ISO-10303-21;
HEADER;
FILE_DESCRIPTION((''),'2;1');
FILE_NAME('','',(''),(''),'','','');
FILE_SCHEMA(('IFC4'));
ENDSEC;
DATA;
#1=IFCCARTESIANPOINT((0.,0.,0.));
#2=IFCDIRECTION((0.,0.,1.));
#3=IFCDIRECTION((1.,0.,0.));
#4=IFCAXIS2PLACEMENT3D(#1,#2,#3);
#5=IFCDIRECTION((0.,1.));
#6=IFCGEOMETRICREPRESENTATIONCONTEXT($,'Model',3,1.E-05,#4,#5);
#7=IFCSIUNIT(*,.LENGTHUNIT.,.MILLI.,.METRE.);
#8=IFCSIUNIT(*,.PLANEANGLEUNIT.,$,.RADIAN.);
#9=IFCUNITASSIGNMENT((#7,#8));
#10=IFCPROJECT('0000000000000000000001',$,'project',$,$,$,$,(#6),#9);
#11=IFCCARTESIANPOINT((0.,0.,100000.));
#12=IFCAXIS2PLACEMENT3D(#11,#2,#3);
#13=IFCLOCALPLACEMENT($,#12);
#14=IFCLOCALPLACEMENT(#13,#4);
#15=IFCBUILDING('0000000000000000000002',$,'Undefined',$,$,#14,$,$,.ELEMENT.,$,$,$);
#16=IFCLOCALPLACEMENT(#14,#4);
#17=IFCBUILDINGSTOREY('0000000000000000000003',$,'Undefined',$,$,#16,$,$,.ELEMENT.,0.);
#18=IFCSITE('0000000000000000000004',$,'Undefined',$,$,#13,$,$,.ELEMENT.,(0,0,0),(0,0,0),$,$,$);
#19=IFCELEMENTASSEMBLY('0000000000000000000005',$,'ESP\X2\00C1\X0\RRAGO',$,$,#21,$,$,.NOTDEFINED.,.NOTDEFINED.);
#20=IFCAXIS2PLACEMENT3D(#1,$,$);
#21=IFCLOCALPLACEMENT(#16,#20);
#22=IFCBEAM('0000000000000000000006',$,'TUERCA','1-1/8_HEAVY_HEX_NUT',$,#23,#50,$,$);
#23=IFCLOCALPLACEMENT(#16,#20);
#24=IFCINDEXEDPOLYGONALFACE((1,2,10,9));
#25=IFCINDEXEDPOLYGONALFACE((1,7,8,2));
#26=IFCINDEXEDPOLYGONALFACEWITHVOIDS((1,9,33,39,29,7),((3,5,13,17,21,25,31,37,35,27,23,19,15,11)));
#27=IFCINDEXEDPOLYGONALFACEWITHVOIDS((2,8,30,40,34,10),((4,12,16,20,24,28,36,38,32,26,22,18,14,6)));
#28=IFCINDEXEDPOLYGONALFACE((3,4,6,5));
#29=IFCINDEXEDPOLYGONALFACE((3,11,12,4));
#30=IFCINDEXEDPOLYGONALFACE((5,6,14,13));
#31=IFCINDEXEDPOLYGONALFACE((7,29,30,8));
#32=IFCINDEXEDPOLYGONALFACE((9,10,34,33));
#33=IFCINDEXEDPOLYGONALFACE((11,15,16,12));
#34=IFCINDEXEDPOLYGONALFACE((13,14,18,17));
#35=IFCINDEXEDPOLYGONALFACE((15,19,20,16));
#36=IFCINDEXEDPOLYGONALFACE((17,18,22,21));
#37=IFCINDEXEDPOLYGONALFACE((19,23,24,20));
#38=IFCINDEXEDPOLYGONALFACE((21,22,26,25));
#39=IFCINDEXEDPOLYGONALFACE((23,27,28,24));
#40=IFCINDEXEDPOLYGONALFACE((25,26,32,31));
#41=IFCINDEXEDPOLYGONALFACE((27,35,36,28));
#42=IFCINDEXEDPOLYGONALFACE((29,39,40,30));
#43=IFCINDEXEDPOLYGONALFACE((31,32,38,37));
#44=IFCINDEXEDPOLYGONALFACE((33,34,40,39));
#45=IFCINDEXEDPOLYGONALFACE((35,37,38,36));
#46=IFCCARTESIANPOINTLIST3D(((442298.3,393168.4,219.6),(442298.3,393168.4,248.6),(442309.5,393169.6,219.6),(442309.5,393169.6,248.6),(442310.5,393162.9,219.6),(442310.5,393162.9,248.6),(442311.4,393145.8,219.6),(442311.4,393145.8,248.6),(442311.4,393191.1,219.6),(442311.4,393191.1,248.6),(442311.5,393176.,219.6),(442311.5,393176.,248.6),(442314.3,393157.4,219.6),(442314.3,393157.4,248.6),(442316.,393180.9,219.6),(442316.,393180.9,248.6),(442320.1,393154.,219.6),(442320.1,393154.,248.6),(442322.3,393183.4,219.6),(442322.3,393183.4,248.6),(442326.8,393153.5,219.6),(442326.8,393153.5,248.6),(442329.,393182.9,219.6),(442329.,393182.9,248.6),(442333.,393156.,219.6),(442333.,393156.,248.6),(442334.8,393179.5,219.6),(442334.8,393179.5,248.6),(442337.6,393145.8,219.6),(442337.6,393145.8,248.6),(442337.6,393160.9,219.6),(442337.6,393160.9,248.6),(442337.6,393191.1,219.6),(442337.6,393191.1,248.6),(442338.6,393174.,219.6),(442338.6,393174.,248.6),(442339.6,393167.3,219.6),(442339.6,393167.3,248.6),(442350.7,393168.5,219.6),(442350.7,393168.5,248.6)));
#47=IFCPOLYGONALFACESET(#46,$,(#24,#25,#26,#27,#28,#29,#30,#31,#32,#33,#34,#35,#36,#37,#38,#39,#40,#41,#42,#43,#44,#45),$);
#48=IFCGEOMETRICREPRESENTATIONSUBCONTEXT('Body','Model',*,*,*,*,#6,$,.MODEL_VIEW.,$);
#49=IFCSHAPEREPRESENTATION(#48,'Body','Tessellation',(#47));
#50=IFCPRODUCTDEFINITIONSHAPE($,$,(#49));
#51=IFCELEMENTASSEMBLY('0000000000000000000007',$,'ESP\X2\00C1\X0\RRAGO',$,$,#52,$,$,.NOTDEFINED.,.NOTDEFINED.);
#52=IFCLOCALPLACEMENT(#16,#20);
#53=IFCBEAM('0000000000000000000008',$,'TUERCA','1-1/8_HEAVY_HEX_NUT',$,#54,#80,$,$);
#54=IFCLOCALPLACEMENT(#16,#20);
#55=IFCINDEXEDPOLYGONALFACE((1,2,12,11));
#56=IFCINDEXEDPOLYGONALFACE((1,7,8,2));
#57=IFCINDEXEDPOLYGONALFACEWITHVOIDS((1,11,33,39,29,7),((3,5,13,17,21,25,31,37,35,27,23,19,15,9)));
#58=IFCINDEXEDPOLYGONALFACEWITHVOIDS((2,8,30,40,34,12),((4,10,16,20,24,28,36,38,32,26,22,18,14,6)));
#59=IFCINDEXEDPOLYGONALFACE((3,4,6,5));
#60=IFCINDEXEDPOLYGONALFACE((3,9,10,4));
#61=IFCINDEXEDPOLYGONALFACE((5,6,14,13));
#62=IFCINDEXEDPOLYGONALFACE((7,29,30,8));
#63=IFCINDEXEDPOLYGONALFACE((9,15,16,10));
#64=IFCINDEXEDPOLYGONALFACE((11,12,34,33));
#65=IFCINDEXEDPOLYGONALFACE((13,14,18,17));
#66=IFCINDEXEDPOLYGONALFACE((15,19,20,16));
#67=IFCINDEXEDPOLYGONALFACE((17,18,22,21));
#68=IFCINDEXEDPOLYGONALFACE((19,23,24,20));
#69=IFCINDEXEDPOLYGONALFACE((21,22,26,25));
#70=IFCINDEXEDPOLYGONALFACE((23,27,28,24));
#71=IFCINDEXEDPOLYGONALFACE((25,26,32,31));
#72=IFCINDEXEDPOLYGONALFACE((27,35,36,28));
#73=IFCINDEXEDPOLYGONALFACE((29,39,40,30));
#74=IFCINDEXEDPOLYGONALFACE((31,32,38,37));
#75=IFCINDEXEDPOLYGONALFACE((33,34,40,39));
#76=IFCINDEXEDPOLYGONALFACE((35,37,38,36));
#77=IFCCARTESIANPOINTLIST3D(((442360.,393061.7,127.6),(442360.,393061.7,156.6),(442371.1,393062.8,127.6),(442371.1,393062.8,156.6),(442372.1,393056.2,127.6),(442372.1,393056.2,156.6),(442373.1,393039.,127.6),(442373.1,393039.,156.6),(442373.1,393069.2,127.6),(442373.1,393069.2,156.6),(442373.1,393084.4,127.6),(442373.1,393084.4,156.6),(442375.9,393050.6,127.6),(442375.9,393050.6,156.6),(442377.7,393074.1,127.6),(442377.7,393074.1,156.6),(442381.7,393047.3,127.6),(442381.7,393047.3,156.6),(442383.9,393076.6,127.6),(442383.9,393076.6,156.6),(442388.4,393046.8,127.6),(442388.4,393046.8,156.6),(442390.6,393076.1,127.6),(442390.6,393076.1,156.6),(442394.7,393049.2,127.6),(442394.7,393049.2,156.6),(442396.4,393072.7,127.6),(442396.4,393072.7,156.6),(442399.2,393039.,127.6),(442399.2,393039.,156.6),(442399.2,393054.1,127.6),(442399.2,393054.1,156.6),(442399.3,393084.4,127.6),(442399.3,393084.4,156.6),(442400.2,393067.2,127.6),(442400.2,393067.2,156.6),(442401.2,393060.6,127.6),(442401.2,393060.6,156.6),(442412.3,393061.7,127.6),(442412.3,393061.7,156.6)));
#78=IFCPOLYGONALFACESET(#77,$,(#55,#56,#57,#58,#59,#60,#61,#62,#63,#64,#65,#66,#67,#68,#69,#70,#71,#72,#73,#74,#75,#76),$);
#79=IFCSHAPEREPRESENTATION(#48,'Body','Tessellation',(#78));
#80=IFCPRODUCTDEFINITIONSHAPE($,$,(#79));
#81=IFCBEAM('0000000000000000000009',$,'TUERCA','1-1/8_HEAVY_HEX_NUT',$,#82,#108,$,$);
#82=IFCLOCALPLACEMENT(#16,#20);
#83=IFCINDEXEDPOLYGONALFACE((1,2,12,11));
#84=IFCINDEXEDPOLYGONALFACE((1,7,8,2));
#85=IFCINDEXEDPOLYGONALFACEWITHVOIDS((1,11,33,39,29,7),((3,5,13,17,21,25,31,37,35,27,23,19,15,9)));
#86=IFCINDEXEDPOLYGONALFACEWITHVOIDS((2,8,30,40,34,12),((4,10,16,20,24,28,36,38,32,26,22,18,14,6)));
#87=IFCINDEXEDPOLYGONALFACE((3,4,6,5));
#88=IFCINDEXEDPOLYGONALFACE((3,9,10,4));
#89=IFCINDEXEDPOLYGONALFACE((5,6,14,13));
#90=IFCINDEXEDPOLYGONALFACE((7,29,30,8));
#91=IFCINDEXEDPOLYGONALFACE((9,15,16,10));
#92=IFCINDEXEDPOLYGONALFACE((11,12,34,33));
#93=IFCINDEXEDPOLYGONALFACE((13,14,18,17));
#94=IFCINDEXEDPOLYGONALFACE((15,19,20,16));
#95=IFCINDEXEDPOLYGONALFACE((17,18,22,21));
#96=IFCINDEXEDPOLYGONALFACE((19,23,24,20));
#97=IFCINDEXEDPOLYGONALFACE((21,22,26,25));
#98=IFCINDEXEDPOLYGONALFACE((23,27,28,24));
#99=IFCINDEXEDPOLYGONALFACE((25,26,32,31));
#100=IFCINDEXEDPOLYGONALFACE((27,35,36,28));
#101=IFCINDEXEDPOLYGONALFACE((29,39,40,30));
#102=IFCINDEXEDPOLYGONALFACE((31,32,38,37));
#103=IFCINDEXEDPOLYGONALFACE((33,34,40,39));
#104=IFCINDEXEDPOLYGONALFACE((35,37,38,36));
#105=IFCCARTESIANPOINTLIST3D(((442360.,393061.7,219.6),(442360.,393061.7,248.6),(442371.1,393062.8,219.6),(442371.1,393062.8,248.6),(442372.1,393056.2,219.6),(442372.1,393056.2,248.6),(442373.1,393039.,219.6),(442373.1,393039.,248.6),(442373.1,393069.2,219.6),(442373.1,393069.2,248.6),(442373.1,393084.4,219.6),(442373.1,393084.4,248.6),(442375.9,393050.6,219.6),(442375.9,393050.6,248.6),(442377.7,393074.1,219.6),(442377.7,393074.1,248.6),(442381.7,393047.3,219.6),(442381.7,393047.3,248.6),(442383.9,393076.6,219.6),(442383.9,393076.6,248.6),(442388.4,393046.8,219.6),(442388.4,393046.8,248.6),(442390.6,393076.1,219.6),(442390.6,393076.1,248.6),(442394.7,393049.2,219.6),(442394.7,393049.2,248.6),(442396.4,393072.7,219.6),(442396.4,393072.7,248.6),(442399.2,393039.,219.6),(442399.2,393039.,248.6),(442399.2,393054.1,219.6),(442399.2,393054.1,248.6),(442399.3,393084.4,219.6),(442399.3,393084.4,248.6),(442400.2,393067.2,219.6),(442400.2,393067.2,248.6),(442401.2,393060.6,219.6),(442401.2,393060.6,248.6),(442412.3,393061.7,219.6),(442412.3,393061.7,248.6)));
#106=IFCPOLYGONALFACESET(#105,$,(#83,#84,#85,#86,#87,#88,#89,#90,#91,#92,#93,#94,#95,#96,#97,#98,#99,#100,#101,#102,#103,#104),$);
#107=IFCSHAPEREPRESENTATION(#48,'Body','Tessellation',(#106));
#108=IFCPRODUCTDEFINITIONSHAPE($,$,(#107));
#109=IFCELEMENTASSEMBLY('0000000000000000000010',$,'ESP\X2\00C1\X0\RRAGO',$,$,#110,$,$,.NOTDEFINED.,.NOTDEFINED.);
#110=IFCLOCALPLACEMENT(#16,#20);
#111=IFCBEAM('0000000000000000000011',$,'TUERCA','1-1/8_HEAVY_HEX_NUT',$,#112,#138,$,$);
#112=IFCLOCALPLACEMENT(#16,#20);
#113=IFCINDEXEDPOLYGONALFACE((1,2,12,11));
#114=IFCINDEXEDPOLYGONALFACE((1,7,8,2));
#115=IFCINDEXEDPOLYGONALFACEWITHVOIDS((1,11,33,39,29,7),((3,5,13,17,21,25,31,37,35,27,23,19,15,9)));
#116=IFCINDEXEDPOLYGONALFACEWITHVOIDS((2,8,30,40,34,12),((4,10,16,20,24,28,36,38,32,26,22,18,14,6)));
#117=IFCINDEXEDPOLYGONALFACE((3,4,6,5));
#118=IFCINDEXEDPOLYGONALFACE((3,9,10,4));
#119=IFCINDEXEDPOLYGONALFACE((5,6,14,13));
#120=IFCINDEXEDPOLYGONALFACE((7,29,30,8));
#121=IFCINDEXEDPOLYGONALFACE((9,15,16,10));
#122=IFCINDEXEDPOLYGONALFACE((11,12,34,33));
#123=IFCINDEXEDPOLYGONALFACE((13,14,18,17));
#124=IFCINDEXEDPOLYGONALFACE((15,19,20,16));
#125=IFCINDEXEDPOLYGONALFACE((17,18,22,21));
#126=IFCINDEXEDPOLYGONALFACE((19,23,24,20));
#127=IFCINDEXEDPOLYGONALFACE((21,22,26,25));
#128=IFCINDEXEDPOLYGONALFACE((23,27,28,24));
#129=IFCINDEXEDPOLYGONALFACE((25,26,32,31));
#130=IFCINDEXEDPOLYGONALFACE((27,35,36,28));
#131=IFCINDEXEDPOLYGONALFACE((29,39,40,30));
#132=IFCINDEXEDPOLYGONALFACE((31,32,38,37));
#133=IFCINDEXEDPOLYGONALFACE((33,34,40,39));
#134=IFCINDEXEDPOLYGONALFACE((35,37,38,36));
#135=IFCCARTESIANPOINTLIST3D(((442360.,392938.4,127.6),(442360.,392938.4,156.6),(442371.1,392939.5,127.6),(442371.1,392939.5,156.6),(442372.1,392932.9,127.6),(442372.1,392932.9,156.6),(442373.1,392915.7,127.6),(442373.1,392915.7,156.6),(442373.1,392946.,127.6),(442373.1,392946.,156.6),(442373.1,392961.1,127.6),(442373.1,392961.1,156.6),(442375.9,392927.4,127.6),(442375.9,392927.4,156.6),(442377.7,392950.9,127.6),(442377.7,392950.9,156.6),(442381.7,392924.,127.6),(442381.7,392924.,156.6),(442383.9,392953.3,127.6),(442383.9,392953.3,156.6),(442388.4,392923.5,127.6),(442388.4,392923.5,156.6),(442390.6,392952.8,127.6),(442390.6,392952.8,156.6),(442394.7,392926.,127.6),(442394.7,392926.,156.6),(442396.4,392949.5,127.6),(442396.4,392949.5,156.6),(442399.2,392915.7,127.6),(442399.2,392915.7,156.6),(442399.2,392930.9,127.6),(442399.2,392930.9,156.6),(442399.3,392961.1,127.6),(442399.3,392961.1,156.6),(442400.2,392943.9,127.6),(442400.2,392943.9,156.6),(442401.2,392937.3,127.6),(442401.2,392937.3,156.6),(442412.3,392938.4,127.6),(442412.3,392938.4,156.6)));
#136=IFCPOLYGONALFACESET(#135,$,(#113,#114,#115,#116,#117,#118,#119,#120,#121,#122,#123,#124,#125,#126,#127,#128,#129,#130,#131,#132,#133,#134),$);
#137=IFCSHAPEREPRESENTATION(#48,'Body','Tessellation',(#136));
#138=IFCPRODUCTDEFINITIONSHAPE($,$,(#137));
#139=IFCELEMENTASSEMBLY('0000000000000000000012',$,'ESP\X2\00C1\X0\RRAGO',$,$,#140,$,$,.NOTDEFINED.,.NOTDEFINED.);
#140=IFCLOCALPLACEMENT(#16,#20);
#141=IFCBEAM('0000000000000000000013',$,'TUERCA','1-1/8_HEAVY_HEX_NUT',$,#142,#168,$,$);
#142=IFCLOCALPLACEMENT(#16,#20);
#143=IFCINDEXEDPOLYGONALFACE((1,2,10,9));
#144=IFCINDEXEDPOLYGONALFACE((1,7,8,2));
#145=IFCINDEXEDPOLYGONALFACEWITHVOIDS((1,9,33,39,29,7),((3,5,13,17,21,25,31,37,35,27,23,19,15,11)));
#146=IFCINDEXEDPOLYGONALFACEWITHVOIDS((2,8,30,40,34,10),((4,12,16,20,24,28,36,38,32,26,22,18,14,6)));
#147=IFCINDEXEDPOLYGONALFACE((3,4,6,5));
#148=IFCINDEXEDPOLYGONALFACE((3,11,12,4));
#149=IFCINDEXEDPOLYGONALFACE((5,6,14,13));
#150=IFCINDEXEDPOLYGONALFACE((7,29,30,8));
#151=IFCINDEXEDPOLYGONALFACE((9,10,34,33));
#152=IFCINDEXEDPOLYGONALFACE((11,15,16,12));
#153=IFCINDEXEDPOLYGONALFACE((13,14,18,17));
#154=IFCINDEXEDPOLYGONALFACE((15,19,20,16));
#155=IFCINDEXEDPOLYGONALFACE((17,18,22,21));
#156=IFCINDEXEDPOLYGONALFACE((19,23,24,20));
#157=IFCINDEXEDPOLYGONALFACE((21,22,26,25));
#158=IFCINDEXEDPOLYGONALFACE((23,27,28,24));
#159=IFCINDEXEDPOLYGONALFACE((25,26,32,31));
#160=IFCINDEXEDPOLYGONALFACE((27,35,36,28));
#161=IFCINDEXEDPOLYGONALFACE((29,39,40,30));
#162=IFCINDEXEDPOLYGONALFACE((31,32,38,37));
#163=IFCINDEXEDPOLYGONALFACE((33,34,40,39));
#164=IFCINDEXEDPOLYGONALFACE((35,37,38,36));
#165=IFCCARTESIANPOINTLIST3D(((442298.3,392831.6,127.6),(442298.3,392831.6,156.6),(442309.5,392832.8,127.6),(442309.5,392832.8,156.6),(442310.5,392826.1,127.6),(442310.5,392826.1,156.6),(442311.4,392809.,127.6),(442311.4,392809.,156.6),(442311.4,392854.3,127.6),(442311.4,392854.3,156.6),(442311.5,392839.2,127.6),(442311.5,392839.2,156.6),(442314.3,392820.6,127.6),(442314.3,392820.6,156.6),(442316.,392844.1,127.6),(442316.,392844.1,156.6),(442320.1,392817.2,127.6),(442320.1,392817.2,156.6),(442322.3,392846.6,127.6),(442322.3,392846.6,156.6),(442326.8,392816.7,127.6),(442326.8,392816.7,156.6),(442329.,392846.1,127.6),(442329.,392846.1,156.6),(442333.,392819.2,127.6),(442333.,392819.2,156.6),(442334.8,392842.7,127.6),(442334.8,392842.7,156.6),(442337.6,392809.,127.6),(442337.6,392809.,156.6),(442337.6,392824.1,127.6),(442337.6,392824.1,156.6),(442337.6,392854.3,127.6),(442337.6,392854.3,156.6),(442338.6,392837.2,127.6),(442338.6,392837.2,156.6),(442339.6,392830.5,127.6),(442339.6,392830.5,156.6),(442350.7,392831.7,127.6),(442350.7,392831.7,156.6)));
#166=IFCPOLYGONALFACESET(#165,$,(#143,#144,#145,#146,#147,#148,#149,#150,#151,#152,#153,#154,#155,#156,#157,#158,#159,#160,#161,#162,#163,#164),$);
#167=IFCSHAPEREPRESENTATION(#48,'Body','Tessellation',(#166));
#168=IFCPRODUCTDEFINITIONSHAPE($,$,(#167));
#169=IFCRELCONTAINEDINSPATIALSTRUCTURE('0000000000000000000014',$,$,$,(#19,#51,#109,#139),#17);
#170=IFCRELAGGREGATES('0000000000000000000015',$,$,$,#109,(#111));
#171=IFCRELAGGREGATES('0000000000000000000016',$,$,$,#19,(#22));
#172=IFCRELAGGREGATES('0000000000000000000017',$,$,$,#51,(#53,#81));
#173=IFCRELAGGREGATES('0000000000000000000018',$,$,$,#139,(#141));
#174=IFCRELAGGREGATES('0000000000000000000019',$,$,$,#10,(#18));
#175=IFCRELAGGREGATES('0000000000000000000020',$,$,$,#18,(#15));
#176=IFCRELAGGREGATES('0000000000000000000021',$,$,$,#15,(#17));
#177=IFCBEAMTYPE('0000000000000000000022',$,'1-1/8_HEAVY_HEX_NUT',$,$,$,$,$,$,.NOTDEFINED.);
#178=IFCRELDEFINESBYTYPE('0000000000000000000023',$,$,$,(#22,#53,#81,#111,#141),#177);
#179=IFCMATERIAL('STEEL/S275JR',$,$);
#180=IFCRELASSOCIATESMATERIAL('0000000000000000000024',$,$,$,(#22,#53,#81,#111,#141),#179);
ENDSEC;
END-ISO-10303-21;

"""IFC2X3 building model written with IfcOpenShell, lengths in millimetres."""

from ifc_helpers import new_model, si_unit, direction, frame, origin_with_axes, place, context, subcontext, project, spatial, polyline, outline, extrude, material, type_object, element, aggregate, save


model = new_model("IFC2X3")

# Units and contexts
model_context = context("Model", 3, precision=1e-05, world=origin_with_axes(), true_north=direction((0.0, 1.0)))
body_context = subcontext(model_context, "Body", "Model", "MODEL_VIEW")
ifc_project = project(units=[si_unit("LENGTHUNIT", "METRE", prefix="MILLI"), si_unit("PLANEANGLEUNIT", "RADIAN")], contexts=[model_context])

# Site, building, storey
site_placement = place(None, frame((0.0, 0.0, 100000.0), z_axis=(0.0, 0.0, 1.0), x_axis=(1.0, 0.0, 0.0)))
site = spatial("IfcSite", under=ifc_project, at=site_placement, Name="Undefined", CompositionType="ELEMENT", RefLatitude=(0, 0, 0), RefLongitude=(0, 0, 0))
building_placement = place(site_placement, origin_with_axes())
building = spatial("IfcBuilding", under=site, at=building_placement, Name="Undefined", CompositionType="ELEMENT")
storey_placement = place(building_placement, origin_with_axes())
storey = spatial("IfcBuildingStorey", under=building, at=storey_placement, Name="Undefined", CompositionType="ELEMENT", Elevation=0.0)

# Element assemblies, beams
ifc_material = material(Name="STEEL/S275JR")
beam_type_1 = type_object("IfcBeamType", Name="1-1/8_HEAVY_HEX_NUT", PredefinedType="NOTDEFINED")
assembly_1_placement = place(storey_placement, origin_with_axes())
assembly_1 = element("IfcElementAssembly", 1, at=assembly_1_placement, inside=storey, Name="ESPÁRRAGO", AssemblyPlace="NOTDEFINED", PredefinedType="NOTDEFINED")
beam_1_placement = place(assembly_1_placement, frame((442324.5, 393168.4, 248.6), z_axis=(0.866025, -0.5, 0.0), x_axis=(0.0, 0.0, -1.0)))
beam_1 = element("IfcBeam", 2, at=beam_1_placement, type_object=beam_type_1, material=ifc_material, Name="TUERCA", Description="1-1/8_HEAVY_HEX_NUT", context=body_context, shape_type="SweptSolid", body=[
    extrude(outline(polyline([(-13.1, -22.7), (-26.2, 0.0), (-13.1, 22.7), (13.1, 22.7), (26.2, 0.0), (13.1, -22.7), (-13.1, -22.7)]), holes=[polyline([(6.5, 13.6), (0.0, 15.1), (-6.5, 13.6), (-11.8, 9.4), (-14.7, 3.4), (-14.7, -3.4), (-11.8, -9.4), (-6.5, -13.6), (0.0, -15.1), (6.5, -13.6), (11.8, -9.4), (14.7, -3.4), (14.7, 3.4), (11.8, 9.4), (6.5, 13.6)])]), frame((29.0, 0.0, 0.0), z_axis=(-1.0, 0.0, 0.0), x_axis=(0.0, -1.0, 0.0)), (0.0, 0.0, 1.0), 29.0),
])
assembly_2_placement = place(storey_placement, origin_with_axes())
assembly_2 = element("IfcElementAssembly", 3, at=assembly_2_placement, inside=storey, Name="ESPÁRRAGO", AssemblyPlace="NOTDEFINED", PredefinedType="NOTDEFINED")
beam_2_placement = place(assembly_2_placement, frame((442386.2, 393061.7, 156.6), z_axis=(0.866025, -0.5, 0.0), x_axis=(0.0, 0.0, -1.0)))
beam_2 = element("IfcBeam", 4, at=beam_2_placement, type_object=beam_type_1, material=ifc_material, Name="TUERCA", Description="1-1/8_HEAVY_HEX_NUT", context=body_context, shape_type="SweptSolid", body=[
    extrude(outline(polyline([(-13.1, -22.7), (-26.2, 0.0), (-13.1, 22.7), (13.1, 22.7), (26.2, 0.0), (13.1, -22.7), (-13.1, -22.7)]), holes=[polyline([(6.5, 13.6), (0.0, 15.1), (-6.5, 13.6), (-11.8, 9.4), (-14.7, 3.4), (-14.7, -3.4), (-11.8, -9.4), (-6.5, -13.6), (0.0, -15.1), (6.5, -13.6), (11.8, -9.4), (14.7, -3.4), (14.7, 3.4), (11.8, 9.4), (6.5, 13.6)])]), frame((29.0, 0.0, 0.0), z_axis=(-1.0, 0.0, 0.0), x_axis=(0.0, -1.0, 0.0)), (0.0, 0.0, 1.0), 29.0),
])
beam_3_placement = place(assembly_2_placement, frame((442386.2, 393061.7, 248.6), z_axis=(0.866025, -0.5, 0.0), x_axis=(0.0, 0.0, -1.0)))
beam_3 = element("IfcBeam", 5, at=beam_3_placement, type_object=beam_type_1, material=ifc_material, Name="TUERCA", Description="1-1/8_HEAVY_HEX_NUT", context=body_context, shape_type="SweptSolid", body=[
    extrude(outline(polyline([(-13.1, -22.7), (-26.2, 0.0), (-13.1, 22.7), (13.1, 22.7), (26.2, 0.0), (13.1, -22.7), (-13.1, -22.7)]), holes=[polyline([(6.5, 13.6), (0.0, 15.1), (-6.5, 13.6), (-11.8, 9.4), (-14.7, 3.4), (-14.7, -3.4), (-11.8, -9.4), (-6.5, -13.6), (0.0, -15.1), (6.5, -13.6), (11.8, -9.4), (14.7, -3.4), (14.7, 3.4), (11.8, 9.4), (6.5, 13.6)])]), frame((29.0, 0.0, 0.0), z_axis=(-1.0, 0.0, 0.0), x_axis=(0.0, -1.0, 0.0)), (0.0, 0.0, 1.0), 29.0),
])

# Element assembly, beam
assembly_3_placement = place(storey_placement, origin_with_axes())
assembly_3 = element("IfcElementAssembly", 6, at=assembly_3_placement, inside=storey, Name="ESPÁRRAGO", AssemblyPlace="NOTDEFINED", PredefinedType="NOTDEFINED")
beam_4_placement = place(assembly_3_placement, frame((442386.2, 392938.4, 156.6), z_axis=(0.866025, -0.5, 0.0), x_axis=(0.0, 0.0, -1.0)))
beam_4 = element("IfcBeam", 7, at=beam_4_placement, type_object=beam_type_1, material=ifc_material, Name="TUERCA", Description="1-1/8_HEAVY_HEX_NUT", context=body_context, shape_type="SweptSolid", body=[
    extrude(outline(polyline([(-13.1, -22.7), (-26.2, 0.0), (-13.1, 22.7), (13.1, 22.7), (26.2, 0.0), (13.1, -22.7), (-13.1, -22.7)]), holes=[polyline([(6.5, 13.6), (0.0, 15.1), (-6.5, 13.6), (-11.8, 9.4), (-14.7, 3.4), (-14.7, -3.4), (-11.8, -9.4), (-6.5, -13.6), (0.0, -15.1), (6.5, -13.6), (11.8, -9.4), (14.7, -3.4), (14.7, 3.4), (11.8, 9.4), (6.5, 13.6)])]), frame((29.0, 0.0, 0.0), z_axis=(-1.0, 0.0, 0.0), x_axis=(0.0, -1.0, 0.0)), (0.0, 0.0, 1.0), 29.0),
])
aggregate(assembly_3, [beam_4])

# Element assembly, beam
assembly_4_placement = place(storey_placement, origin_with_axes())
assembly_4 = element("IfcElementAssembly", 8, at=assembly_4_placement, inside=storey, Name="ESPÁRRAGO", AssemblyPlace="NOTDEFINED", PredefinedType="NOTDEFINED")
beam_5_placement = place(assembly_4_placement, frame((442324.5, 392831.7, 156.6), z_axis=(0.866025, -0.5, 0.0), x_axis=(0.0, 0.0, -1.0)))
beam_5 = element("IfcBeam", 9, at=beam_5_placement, type_object=beam_type_1, material=ifc_material, Name="TUERCA", Description="1-1/8_HEAVY_HEX_NUT", context=body_context, shape_type="SweptSolid", body=[
    extrude(outline(polyline([(-13.1, -22.7), (-26.2, 0.0), (-13.1, 22.7), (13.1, 22.7), (26.2, 0.0), (13.1, -22.7), (-13.1, -22.7)]), holes=[polyline([(6.5, 13.6), (0.0, 15.1), (-6.5, 13.6), (-11.8, 9.4), (-14.7, 3.4), (-14.7, -3.4), (-11.8, -9.4), (-6.5, -13.6), (0.0, -15.1), (6.5, -13.6), (11.8, -9.4), (14.7, -3.4), (14.7, 3.4), (11.8, 9.4), (6.5, 13.6)])]), frame((29.0, 0.0, 0.0), z_axis=(-1.0, 0.0, 0.0), x_axis=(0.0, -1.0, 0.0)), (0.0, 0.0, 1.0), 29.0),
])

aggregate(assembly_1, [beam_1])
aggregate(assembly_2, [beam_2, beam_3])
aggregate(assembly_4, [beam_5])

save(model, "model.ifc")
